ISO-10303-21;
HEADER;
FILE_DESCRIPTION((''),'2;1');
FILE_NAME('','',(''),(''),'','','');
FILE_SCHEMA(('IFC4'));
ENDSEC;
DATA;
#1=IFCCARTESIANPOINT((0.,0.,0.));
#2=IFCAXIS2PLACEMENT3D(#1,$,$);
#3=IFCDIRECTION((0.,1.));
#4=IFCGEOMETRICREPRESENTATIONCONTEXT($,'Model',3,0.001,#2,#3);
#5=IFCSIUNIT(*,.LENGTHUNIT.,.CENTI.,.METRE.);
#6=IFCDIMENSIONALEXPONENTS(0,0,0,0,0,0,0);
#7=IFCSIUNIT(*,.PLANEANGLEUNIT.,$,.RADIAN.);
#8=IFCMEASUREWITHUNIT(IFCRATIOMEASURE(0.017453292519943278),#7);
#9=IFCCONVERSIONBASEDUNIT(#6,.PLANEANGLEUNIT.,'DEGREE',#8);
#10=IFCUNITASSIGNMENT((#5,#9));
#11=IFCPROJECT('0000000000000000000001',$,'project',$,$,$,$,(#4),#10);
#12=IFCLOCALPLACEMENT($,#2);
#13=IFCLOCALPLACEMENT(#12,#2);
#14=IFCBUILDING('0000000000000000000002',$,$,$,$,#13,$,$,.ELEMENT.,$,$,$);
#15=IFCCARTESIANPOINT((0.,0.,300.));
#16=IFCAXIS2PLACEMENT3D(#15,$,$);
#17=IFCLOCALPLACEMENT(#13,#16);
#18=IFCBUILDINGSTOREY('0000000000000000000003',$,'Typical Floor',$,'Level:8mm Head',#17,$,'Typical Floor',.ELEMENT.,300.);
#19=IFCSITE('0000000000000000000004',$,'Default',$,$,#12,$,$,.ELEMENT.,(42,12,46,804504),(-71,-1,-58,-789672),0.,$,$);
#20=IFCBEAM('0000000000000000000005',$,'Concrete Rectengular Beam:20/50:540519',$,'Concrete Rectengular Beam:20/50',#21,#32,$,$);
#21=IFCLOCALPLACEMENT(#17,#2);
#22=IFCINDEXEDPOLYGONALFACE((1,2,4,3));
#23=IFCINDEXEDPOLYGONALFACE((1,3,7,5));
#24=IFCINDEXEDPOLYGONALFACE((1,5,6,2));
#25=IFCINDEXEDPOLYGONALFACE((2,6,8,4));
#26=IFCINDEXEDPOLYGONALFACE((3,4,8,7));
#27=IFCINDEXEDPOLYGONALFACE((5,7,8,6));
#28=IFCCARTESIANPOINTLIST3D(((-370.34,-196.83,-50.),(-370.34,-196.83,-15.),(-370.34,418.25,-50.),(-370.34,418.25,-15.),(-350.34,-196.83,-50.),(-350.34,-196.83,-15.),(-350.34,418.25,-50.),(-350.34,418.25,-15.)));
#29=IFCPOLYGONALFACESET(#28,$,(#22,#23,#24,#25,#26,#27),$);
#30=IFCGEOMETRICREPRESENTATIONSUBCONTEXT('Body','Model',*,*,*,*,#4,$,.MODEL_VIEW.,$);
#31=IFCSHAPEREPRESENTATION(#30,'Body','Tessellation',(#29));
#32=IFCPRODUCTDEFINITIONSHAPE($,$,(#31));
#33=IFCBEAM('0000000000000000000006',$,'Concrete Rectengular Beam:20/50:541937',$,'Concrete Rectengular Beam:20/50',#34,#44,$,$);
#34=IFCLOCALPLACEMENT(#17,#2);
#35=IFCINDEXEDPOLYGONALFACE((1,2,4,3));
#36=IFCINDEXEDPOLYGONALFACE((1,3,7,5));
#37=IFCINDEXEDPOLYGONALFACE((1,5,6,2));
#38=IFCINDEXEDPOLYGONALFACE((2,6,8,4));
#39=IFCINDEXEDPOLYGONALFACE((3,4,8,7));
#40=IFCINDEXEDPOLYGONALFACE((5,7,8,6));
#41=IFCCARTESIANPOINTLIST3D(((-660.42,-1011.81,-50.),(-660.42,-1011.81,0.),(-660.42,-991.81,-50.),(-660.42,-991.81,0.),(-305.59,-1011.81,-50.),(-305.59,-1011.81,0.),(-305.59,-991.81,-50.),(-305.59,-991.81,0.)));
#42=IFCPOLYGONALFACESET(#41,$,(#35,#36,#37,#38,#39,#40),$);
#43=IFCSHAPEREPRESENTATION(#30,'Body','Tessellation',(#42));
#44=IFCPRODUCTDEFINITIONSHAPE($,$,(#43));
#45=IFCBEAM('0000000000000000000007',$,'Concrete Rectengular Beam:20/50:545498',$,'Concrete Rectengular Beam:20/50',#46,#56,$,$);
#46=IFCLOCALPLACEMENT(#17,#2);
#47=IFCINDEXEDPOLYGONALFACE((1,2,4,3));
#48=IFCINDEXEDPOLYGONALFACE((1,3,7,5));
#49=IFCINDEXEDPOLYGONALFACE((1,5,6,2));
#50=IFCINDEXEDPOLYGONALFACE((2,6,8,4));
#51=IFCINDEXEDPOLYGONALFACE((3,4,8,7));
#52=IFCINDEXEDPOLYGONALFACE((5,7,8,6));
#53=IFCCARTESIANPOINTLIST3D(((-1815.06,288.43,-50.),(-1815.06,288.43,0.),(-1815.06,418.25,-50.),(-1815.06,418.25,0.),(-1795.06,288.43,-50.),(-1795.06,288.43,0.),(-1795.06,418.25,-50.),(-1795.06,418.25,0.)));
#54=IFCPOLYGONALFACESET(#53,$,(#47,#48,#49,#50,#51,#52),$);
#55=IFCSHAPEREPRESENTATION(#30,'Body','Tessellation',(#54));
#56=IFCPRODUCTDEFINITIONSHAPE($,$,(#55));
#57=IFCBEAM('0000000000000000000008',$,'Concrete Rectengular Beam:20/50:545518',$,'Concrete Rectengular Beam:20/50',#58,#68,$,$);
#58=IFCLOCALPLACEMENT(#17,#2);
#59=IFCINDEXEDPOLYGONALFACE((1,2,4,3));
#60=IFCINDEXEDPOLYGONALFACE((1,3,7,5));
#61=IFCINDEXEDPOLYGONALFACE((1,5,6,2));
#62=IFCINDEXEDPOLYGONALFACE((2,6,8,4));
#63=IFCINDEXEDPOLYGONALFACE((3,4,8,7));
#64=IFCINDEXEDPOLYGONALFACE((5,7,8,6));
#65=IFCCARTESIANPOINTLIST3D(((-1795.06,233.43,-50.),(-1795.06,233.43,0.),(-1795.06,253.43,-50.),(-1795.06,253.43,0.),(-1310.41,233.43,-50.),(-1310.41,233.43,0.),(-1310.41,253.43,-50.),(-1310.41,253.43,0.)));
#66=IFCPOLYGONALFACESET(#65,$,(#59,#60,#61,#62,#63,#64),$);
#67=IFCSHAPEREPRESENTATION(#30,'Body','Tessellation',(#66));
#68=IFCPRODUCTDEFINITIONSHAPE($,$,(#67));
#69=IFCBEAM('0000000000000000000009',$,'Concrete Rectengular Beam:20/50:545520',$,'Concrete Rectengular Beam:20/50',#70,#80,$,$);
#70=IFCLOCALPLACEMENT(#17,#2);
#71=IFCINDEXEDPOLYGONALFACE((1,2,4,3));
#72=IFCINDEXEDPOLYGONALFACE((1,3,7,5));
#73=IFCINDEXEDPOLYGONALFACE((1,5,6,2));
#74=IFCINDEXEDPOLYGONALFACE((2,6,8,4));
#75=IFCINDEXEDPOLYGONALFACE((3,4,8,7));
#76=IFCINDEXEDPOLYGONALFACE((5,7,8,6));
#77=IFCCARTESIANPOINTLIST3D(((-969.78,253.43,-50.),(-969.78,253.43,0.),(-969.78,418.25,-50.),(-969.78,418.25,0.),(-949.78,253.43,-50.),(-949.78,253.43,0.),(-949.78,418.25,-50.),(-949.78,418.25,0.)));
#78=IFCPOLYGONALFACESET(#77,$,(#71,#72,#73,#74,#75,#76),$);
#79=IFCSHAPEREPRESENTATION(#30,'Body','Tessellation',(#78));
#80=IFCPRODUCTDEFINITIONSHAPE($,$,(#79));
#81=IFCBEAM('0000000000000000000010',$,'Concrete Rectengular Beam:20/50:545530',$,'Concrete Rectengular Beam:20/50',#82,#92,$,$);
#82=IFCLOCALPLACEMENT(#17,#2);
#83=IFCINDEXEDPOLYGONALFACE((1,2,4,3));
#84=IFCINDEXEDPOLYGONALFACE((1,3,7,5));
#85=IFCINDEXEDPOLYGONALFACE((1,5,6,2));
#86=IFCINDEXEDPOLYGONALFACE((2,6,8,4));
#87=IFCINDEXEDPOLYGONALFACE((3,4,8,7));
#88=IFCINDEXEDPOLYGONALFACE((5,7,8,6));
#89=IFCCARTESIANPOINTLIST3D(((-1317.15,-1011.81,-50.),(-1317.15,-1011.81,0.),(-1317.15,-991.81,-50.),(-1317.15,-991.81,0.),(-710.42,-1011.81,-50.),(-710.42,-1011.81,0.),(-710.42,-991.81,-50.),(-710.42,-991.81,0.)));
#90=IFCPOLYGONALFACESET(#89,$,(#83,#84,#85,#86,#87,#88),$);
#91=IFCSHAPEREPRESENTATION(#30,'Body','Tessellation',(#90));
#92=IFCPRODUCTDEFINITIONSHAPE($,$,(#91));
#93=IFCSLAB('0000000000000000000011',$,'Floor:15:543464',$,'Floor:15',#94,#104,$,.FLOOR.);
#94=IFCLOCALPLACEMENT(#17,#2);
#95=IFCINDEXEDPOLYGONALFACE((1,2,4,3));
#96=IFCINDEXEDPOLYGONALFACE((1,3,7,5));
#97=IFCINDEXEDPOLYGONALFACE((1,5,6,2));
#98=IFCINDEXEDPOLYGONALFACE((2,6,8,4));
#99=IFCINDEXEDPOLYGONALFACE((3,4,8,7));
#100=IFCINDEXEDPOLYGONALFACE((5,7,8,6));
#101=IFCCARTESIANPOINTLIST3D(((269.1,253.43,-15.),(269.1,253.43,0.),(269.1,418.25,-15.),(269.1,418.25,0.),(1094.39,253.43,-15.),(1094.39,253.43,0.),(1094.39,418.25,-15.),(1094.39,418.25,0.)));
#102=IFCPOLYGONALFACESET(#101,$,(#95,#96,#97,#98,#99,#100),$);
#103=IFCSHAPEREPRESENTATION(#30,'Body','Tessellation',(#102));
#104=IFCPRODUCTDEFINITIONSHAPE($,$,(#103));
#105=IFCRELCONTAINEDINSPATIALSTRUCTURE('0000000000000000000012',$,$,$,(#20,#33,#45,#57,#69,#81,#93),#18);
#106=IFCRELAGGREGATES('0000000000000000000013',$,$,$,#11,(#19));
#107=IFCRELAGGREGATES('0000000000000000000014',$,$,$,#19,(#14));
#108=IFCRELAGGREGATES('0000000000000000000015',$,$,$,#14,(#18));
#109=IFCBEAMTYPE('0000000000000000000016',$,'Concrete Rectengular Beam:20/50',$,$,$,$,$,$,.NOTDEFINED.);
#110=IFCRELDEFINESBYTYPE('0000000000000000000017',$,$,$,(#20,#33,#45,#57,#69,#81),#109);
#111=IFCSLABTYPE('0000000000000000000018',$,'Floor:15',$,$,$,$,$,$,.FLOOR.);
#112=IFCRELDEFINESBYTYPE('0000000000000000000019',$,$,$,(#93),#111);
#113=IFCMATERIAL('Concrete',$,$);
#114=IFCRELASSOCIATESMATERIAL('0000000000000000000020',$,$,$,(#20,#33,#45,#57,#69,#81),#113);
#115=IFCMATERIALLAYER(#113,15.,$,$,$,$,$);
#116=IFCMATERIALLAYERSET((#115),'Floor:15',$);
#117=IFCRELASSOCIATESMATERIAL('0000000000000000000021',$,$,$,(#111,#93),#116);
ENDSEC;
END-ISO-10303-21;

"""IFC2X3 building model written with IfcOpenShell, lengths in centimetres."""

from ifc_helpers import new_model, entity, si_unit, converted_unit, direction, frame, frame_2d, origin, place, context, subcontext, project, spatial, rectangle, extrude, material, layer, layer_set, layer_usage, type_object, element, save


model = new_model("IFC2X3")

# Units and contexts
model_context = context("Model", 3, precision=0.001, world=origin(), true_north=direction((0.0, 1.0)))
body_context = subcontext(model_context, "Body", "Model", "MODEL_VIEW")
ifc_project = project(units=[si_unit("LENGTHUNIT", "METRE", prefix="CENTI"), converted_unit("PLANEANGLEUNIT", "DEGREE", entity("IfcRatioMeasure", 0.017453292519943278), si_unit("PLANEANGLEUNIT", "RADIAN"), dimensions=[0, 0, 0, 0, 0, 0, 0])], contexts=[model_context])

# Site, building, storey
site_placement = place(None, origin())
site = spatial("IfcSite", under=ifc_project, at=site_placement, Name="Default", CompositionType="ELEMENT", RefLatitude=(42, 12, 46, 804504), RefLongitude=(-71, -1, -58, -789672), RefElevation=0.0)
building_placement = place(site_placement, origin())
building = spatial("IfcBuilding", under=site, at=building_placement, CompositionType="ELEMENT")
storey_placement = place(building_placement, frame((0.0, 0.0, 300.0)))
storey = spatial("IfcBuildingStorey", under=building, at=storey_placement, Name="Typical Floor", ObjectType="Level:8mm Head", LongName="Typical Floor", CompositionType="ELEMENT", Elevation=300.0)

# Beams
ifc_material = material(Name="Concrete")
beam_type = type_object("IfcBeamType", Name="Concrete Rectengular Beam:20/50", PredefinedType="NOTDEFINED")
beam_1_placement = place(storey_placement, frame((-360.34, 428.25, 0.0), z_axis=(0.0, 0.0, 1.0), x_axis=(0.0, -1.0, 0.0)))
element("IfcBeam", 1, at=beam_1_placement, inside=storey, type_object=beam_type, material=ifc_material, Name="Concrete Rectengular Beam:20/50:540519", ObjectType="Concrete Rectengular Beam:20/50", context=body_context, shape_type="SweptSolid", body=[
    extrude(rectangle(XDim=35.0, YDim=20.0, at=frame_2d((0.0, 0.0), x_axis=(1.0, 0.0))), frame((10.0, 0.0, -32.5), z_axis=(1.0, 0.0, 0.0), x_axis=(0.0, 0.0, -1.0)), (0.0, 0.0, 1.0), 615.08),
])
beam_2_placement = place(storey_placement, frame((-685.42, -1001.81, 0.0)))
element("IfcBeam", 2, at=beam_2_placement, inside=storey, type_object=beam_type, material=ifc_material, Name="Concrete Rectengular Beam:20/50:541937", ObjectType="Concrete Rectengular Beam:20/50", context=body_context, shape_type="SweptSolid", body=[
    extrude(rectangle(XDim=50.0, YDim=20.0, at=frame_2d((0.0, 0.0), x_axis=(1.0, 0.0))), frame((25.0, 0.0, -25.0), z_axis=(1.0, 0.0, 0.0), x_axis=(0.0, 0.0, -1.0)), (0.0, 0.0, 1.0), 354.84),
])
beam_3_placement = place(storey_placement, frame((-1805.06, 428.25, 0.0), z_axis=(0.0, 0.0, 1.0), x_axis=(0.0, -1.0, 0.0)))
element("IfcBeam", 3, at=beam_3_placement, inside=storey, type_object=beam_type, material=ifc_material, Name="Concrete Rectengular Beam:20/50:545498", ObjectType="Concrete Rectengular Beam:20/50", context=body_context, shape_type="SweptSolid", body=[
    extrude(rectangle(XDim=50.0, YDim=20.0, at=frame_2d((0.0, 0.0), x_axis=(1.0, 0.0))), frame((10.0, 0.0, -25.0), z_axis=(1.0, 0.0, 0.0), x_axis=(0.0, 0.0, -1.0)), (0.0, 0.0, 1.0), 129.82),
])
beam_4_placement = place(storey_placement, frame((-1805.06, 243.43, 0.0)))
element("IfcBeam", 4, at=beam_4_placement, inside=storey, type_object=beam_type, material=ifc_material, Name="Concrete Rectengular Beam:20/50:545518", ObjectType="Concrete Rectengular Beam:20/50", context=body_context, shape_type="SweptSolid", body=[
    extrude(rectangle(XDim=50.0, YDim=20.0, at=frame_2d((0.0, 0.0), x_axis=(1.0, 0.0))), frame((10.0, 0.0, -25.0), z_axis=(1.0, 0.0, 0.0), x_axis=(0.0, 0.0, -1.0)), (0.0, 0.0, 1.0), 484.65),
])
beam_5_placement = place(storey_placement, frame((-959.78, 428.25, 0.0), z_axis=(0.0, 0.0, 1.0), x_axis=(0.0, -1.0, 0.0)))
element("IfcBeam", 5, at=beam_5_placement, inside=storey, type_object=beam_type, material=ifc_material, Name="Concrete Rectengular Beam:20/50:545520", ObjectType="Concrete Rectengular Beam:20/50", context=body_context, shape_type="SweptSolid", body=[
    extrude(rectangle(XDim=50.0, YDim=20.0, at=frame_2d((0.0, 0.0), x_axis=(1.0, 0.0))), frame((10.0, 0.0, -25.0), z_axis=(1.0, 0.0, 0.0), x_axis=(0.0, 0.0, -1.0)), (0.0, 0.0, 1.0), 164.82),
])
beam_6_placement = place(storey_placement, frame((-1367.15, -1001.81, 0.0)))
element("IfcBeam", 6, at=beam_6_placement, inside=storey, type_object=beam_type, material=ifc_material, Name="Concrete Rectengular Beam:20/50:545530", ObjectType="Concrete Rectengular Beam:20/50", context=body_context, shape_type="SweptSolid", body=[
    extrude(rectangle(XDim=50.0, YDim=20.0, at=frame_2d((0.0, 0.0), x_axis=(1.0, 0.0))), frame((50.0, 0.0, -25.0), z_axis=(1.0, 0.0, 0.0), x_axis=(0.0, 0.0, -1.0)), (0.0, 0.0, 1.0), 606.73),
])

# Slab
ifc_layer = layer(ifc_material, 15.0)
ifc_layer_set = layer_set([ifc_layer], Name="Floor:15")
ifc_layer_usage = layer_usage(ifc_layer_set, "AXIS3", "POSITIVE", 0.0)
slab_type = type_object("IfcSlabType", Name="Floor:15", PredefinedType="FLOOR", material=ifc_layer_set)
slab_placement = place(storey_placement, origin())
element("IfcSlab", 7, at=slab_placement, inside=storey, type_object=slab_type, material=ifc_layer_usage, Name="Floor:15:543464", ObjectType="Floor:15", PredefinedType="FLOOR", context=body_context, shape_type="SweptSolid", body=[
    extrude(rectangle(XDim=164.82, YDim=825.28, at=frame_2d((0.0, 0.0), x_axis=(1.0, 0.0))), frame((681.75, 335.84, 0.0), z_axis=(0.0, 0.0, -1.0), x_axis=(0.0, 1.0, 0.0)), (0.0, 0.0, 1.0), 15.0),
])

save(model, "model.ifc")
